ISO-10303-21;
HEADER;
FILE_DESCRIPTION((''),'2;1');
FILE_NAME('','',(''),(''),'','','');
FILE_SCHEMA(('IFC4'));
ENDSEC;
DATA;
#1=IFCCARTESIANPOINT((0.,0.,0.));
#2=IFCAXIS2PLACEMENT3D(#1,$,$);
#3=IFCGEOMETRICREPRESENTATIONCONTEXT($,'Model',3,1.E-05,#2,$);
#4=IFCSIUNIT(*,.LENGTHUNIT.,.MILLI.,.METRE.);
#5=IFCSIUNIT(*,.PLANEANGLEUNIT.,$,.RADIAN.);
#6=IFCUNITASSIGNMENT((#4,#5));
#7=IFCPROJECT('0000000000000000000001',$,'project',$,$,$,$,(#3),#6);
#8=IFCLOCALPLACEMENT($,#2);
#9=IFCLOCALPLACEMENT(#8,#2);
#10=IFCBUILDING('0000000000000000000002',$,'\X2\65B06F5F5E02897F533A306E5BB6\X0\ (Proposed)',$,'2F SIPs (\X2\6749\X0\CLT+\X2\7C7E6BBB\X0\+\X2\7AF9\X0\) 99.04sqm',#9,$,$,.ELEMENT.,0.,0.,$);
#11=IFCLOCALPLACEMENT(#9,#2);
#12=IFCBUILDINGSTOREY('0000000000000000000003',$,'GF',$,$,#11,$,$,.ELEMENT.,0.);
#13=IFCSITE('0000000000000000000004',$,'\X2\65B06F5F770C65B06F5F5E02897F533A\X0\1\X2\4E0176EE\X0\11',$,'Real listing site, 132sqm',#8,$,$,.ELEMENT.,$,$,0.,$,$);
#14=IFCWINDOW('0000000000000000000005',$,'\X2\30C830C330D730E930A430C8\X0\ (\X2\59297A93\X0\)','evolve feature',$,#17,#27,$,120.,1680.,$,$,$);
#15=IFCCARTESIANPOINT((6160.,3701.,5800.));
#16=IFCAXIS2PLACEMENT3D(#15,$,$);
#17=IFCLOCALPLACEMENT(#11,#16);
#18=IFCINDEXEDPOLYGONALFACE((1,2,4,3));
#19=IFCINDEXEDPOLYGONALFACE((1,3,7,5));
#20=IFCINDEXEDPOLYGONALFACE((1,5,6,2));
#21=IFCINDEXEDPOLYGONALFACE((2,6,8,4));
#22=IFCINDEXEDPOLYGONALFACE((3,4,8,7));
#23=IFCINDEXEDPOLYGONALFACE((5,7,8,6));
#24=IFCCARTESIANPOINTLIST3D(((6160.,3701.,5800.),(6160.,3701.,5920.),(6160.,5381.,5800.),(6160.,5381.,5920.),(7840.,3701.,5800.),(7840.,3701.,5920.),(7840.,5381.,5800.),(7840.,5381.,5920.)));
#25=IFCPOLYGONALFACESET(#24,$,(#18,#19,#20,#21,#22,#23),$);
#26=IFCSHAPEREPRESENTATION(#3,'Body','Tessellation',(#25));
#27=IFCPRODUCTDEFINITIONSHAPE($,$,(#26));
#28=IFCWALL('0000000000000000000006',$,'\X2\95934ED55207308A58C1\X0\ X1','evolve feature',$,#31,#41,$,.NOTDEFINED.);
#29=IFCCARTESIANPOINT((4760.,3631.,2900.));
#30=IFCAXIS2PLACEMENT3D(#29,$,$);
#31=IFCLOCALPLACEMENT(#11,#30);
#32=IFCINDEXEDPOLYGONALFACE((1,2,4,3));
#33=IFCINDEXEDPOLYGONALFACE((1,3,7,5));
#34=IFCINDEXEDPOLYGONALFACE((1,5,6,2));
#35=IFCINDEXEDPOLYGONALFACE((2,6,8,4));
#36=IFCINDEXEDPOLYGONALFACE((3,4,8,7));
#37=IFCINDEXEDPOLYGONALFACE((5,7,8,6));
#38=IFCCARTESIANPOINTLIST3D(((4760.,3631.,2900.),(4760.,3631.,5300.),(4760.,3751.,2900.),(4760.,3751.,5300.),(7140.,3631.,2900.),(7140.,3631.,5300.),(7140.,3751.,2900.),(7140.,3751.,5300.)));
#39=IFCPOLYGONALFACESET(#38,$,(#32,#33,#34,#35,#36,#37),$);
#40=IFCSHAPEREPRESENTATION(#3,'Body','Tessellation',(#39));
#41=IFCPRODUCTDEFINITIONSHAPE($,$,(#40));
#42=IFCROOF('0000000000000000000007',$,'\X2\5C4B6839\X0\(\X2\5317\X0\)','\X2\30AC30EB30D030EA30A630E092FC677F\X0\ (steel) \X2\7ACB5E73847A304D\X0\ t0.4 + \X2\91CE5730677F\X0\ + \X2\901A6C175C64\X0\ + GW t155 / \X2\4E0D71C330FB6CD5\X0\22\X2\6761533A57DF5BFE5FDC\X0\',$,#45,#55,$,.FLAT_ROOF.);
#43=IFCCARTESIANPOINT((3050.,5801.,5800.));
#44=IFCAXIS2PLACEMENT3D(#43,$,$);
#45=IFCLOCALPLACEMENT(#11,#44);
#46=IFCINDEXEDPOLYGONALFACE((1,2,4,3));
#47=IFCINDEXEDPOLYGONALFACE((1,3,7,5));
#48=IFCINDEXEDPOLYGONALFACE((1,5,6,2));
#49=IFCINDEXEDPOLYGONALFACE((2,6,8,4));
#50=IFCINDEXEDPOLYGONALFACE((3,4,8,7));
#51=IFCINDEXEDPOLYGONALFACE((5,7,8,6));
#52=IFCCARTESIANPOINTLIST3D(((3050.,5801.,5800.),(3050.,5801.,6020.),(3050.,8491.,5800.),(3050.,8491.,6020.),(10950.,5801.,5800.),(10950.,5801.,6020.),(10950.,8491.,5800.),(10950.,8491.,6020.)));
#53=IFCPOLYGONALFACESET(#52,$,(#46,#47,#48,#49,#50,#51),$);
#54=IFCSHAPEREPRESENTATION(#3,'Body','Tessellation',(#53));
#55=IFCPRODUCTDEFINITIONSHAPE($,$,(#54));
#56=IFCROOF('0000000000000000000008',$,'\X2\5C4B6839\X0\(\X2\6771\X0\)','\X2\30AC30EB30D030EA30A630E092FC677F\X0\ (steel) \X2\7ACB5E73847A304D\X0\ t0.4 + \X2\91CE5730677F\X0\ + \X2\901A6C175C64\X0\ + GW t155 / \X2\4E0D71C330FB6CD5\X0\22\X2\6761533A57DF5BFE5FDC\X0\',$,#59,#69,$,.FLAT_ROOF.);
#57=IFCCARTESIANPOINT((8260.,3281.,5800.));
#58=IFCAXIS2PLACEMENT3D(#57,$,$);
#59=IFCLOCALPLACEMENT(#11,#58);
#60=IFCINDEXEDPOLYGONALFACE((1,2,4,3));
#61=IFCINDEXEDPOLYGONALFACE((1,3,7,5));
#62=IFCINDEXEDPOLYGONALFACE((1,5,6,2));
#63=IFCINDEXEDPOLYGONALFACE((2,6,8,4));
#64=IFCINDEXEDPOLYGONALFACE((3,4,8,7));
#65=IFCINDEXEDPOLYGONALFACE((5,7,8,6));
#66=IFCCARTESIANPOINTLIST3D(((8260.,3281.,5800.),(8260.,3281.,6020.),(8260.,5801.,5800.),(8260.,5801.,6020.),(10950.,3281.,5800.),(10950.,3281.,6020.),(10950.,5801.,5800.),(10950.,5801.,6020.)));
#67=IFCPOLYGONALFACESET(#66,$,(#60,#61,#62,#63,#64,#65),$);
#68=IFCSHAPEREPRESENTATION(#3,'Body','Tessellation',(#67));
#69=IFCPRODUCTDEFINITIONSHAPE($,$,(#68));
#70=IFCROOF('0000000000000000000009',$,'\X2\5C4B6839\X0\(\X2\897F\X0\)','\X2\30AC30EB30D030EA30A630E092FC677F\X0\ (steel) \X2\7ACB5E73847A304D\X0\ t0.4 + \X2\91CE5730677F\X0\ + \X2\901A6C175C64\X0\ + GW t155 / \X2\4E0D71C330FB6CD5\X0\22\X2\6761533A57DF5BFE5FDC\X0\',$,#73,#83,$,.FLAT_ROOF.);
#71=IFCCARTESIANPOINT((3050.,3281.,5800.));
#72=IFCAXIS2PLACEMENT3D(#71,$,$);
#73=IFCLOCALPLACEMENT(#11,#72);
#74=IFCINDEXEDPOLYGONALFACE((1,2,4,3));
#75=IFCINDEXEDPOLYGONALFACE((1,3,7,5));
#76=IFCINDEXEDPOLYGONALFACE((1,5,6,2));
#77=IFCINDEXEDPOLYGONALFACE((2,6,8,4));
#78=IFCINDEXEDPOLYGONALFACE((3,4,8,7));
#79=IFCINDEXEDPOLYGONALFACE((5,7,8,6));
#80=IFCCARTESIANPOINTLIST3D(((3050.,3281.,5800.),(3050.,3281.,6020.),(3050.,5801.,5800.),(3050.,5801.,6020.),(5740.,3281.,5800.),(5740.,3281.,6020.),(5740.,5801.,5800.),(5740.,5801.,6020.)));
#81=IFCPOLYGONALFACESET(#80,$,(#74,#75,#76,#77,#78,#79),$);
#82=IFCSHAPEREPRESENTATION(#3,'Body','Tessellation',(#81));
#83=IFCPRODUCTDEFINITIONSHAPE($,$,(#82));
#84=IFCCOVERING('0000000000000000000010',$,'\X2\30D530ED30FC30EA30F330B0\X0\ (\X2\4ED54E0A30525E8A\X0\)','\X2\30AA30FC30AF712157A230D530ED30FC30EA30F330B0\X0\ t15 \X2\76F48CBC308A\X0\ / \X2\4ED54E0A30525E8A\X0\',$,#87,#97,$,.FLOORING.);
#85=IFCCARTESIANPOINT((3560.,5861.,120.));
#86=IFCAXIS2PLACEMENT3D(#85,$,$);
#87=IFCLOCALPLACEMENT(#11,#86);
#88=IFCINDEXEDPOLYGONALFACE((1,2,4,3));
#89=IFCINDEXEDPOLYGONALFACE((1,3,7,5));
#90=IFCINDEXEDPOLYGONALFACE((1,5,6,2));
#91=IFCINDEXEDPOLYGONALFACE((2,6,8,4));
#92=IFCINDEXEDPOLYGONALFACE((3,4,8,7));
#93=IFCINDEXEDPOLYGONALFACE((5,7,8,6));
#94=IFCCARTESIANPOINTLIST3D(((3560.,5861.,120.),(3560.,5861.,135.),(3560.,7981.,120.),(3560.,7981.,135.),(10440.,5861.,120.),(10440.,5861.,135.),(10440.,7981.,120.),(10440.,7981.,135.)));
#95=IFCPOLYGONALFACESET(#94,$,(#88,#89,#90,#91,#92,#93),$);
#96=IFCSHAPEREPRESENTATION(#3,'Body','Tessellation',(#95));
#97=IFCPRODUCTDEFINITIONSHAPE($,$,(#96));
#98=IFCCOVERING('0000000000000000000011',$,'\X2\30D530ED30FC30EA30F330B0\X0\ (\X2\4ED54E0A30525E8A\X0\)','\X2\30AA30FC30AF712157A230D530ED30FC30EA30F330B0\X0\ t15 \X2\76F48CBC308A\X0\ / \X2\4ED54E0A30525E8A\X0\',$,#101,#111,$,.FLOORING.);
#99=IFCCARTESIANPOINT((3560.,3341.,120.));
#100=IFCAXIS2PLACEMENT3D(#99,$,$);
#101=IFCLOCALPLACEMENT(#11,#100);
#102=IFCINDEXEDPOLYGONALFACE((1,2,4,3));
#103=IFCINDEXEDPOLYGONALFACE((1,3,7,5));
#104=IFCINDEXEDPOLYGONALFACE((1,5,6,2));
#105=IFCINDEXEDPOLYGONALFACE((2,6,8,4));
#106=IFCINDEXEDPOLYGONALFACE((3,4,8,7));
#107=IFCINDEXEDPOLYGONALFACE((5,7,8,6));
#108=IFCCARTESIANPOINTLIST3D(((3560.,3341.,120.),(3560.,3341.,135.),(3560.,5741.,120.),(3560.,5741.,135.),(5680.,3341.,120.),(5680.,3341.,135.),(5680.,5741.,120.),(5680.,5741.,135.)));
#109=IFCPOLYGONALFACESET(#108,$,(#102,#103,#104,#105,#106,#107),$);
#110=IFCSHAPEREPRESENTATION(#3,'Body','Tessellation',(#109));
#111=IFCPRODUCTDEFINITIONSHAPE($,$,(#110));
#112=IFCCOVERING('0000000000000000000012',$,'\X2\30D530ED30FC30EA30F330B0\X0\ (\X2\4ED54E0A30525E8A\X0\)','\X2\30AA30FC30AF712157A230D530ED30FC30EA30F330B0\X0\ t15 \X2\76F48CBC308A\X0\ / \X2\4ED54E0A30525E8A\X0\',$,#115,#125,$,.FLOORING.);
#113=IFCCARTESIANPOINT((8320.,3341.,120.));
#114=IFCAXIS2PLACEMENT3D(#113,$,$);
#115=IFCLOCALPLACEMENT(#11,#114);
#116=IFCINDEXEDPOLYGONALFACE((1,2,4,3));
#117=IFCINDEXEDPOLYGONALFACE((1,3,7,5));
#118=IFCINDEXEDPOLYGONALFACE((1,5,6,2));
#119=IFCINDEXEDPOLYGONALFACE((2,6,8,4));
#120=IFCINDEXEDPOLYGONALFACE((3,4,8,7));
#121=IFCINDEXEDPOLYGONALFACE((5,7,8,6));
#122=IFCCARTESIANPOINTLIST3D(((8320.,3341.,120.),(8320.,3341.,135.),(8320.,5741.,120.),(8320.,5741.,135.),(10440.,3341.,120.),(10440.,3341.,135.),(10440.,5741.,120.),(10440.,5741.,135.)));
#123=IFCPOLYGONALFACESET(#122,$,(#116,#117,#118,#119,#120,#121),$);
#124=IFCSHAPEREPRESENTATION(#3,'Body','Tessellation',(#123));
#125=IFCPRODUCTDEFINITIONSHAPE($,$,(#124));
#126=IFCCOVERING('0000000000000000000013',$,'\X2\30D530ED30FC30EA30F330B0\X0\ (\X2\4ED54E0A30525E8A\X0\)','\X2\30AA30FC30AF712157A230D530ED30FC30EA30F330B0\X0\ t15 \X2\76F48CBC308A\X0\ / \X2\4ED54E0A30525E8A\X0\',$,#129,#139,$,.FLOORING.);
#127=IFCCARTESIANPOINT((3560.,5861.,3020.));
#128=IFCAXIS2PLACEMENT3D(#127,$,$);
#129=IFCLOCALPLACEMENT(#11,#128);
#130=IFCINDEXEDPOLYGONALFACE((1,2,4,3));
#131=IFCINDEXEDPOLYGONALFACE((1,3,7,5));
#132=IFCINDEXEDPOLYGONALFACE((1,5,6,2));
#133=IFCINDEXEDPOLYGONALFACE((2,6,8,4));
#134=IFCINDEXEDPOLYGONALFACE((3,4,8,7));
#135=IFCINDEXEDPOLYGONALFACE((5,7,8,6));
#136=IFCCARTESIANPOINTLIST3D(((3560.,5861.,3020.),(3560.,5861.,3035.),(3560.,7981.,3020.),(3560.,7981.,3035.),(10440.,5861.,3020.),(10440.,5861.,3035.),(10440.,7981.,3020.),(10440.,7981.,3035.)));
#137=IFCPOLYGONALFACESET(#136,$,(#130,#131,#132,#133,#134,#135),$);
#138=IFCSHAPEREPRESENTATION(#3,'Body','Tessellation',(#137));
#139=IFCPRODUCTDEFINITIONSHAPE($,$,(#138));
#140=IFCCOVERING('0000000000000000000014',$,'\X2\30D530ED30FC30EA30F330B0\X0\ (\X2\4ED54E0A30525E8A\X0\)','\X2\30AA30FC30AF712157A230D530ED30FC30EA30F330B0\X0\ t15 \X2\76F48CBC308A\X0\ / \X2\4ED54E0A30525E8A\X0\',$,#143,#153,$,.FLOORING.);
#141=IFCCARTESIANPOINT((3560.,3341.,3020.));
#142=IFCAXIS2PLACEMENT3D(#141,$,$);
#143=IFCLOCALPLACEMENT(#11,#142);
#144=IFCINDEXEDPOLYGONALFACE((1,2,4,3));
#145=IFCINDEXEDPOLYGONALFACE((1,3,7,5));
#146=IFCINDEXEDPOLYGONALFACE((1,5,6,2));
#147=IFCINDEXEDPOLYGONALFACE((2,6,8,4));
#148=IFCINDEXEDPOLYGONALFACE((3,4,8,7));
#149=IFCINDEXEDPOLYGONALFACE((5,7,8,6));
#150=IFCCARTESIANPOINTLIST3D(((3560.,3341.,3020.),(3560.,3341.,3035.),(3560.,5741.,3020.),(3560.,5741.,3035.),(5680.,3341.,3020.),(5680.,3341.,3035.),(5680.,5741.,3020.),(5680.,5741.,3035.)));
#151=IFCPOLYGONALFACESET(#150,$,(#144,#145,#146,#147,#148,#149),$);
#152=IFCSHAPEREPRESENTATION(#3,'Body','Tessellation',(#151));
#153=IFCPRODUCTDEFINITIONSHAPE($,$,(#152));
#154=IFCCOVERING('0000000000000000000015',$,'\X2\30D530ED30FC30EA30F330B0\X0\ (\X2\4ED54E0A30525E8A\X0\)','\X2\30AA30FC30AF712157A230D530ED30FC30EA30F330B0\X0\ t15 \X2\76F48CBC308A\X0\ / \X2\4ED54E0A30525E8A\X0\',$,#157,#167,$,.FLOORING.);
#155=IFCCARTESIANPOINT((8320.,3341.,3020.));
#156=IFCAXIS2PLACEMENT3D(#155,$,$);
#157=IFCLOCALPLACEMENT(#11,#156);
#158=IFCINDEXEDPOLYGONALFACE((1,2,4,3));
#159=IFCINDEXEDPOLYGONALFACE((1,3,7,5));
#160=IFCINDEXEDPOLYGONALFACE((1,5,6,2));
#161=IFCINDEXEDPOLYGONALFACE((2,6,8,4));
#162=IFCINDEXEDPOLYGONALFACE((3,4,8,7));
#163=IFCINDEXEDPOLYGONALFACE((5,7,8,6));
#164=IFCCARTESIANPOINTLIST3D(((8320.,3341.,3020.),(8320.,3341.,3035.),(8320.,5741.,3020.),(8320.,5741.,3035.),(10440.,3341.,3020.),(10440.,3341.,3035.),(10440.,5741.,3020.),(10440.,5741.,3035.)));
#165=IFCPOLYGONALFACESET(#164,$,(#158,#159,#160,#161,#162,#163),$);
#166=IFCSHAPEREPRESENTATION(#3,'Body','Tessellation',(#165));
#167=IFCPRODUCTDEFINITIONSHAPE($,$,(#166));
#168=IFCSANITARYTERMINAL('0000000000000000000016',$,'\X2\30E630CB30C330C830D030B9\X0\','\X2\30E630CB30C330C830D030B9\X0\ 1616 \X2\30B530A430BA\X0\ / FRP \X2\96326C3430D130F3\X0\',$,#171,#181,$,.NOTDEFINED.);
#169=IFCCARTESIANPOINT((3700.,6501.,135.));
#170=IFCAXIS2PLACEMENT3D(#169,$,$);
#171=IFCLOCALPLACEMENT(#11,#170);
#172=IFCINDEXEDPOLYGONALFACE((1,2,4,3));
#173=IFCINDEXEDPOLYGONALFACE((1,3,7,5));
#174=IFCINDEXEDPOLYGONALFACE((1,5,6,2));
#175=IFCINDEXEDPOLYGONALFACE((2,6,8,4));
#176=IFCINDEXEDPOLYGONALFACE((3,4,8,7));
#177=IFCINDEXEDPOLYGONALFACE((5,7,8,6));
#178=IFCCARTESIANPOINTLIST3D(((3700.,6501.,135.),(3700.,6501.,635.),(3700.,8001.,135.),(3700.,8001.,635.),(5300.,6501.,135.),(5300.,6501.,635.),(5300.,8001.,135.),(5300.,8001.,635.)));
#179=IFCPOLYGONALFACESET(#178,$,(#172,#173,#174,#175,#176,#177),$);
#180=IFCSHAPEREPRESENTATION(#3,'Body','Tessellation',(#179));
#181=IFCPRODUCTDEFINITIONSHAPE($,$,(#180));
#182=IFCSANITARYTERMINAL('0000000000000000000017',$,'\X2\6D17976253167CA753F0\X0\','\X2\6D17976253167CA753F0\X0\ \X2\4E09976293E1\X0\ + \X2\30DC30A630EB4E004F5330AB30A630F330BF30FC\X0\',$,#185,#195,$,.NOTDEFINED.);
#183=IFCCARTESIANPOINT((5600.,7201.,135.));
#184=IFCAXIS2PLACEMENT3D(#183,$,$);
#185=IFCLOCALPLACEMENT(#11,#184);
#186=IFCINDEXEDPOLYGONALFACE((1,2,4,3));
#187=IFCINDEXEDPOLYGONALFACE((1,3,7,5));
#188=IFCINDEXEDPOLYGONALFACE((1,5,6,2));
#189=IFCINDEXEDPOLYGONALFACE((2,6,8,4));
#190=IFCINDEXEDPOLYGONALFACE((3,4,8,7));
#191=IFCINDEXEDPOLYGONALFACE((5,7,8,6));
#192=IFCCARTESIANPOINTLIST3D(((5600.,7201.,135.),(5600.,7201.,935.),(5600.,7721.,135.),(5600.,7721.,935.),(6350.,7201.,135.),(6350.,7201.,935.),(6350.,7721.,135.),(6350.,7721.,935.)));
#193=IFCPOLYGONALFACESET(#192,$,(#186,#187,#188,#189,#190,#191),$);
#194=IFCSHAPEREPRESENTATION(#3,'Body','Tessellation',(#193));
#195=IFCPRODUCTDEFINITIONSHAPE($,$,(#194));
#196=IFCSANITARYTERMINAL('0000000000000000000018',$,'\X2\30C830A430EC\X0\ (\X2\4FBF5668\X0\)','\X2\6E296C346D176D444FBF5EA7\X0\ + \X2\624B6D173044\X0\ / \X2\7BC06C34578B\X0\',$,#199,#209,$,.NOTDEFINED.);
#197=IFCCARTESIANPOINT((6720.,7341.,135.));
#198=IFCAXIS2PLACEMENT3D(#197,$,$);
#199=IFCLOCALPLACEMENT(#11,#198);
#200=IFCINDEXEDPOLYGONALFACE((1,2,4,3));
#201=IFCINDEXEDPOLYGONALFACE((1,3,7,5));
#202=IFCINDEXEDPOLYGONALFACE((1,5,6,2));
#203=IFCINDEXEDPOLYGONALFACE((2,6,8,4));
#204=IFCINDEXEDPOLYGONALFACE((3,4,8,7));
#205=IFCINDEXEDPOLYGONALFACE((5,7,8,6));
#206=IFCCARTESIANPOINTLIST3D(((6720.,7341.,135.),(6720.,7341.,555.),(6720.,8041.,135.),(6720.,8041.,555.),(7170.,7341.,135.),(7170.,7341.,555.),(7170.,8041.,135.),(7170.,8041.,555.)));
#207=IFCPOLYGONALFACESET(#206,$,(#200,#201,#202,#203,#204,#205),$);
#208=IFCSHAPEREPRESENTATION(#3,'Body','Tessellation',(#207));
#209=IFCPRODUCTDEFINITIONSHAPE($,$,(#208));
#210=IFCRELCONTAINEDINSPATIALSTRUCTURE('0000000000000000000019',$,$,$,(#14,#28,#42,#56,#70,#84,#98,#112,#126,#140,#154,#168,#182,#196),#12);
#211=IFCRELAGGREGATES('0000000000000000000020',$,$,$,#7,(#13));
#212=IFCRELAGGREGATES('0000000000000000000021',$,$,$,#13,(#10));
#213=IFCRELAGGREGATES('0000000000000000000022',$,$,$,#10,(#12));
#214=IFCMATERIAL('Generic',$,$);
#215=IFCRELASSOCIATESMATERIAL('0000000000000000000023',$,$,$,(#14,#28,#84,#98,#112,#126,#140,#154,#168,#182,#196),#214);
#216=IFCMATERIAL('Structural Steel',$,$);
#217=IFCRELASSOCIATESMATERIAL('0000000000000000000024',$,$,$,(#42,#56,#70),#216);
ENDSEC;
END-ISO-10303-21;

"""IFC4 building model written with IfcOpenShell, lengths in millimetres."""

from ifc_helpers import new_model, si_unit, frame, frame_2d, origin, place, context, project, spatial, rectangle, extrude, material, element, save


model = new_model("IFC4")

# Units and contexts
model_context = context("Model", 3, precision=1e-05, world=origin())
ifc_project = project(units=[si_unit("LENGTHUNIT", "METRE", prefix="MILLI"), si_unit("PLANEANGLEUNIT", "RADIAN")], contexts=[model_context])

# Site, building, storey
site_placement = place(None, origin())
site = spatial("IfcSite", under=ifc_project, at=site_placement, Name="新潟県新潟市西区1丁目11", ObjectType="Real listing site, 132sqm", CompositionType="ELEMENT", RefElevation=0.0)
building_placement = place(site_placement, origin())
building = spatial("IfcBuilding", under=site, at=building_placement, Name="新潟市西区の家 (Proposed)", ObjectType="2F SIPs (杉CLT+籾殻+竹) 99.04sqm", CompositionType="ELEMENT", ElevationOfRefHeight=0.0, ElevationOfTerrain=0.0)
storey_placement = place(building_placement, origin())
storey = spatial("IfcBuildingStorey", under=building, at=storey_placement, Name="GF", CompositionType="ELEMENT", Elevation=0.0)

# Window
ifc_material_1 = material(Name="Generic")
window_1_placement = place(storey_placement, frame((6160.0, 3701.0, 5800.0)))
element("IfcWindow", 1, at=window_1_placement, inside=storey, material=ifc_material_1, Name="トップライト (天窓)", Description="evolve feature", OverallHeight=120.0, OverallWidth=1680.0, context=model_context, shape_type="SweptSolid", body=[
    extrude(rectangle(XDim=1680.0, YDim=1680.0, at=frame_2d((840.0, 840.0))), frame((6160.0, 3701.0, 5800.0)), (0.0, 0.0, 1.0), 120.0),
])

# Wall
wall_1_placement = place(storey_placement, frame((4760.0, 3631.0, 2900.0)))
element("IfcWall", 2, at=wall_1_placement, inside=storey, material=ifc_material_1, Name="間仕切り壁 X1", Description="evolve feature", PredefinedType="NOTDEFINED", context=model_context, shape_type="SweptSolid", body=[
    extrude(rectangle(XDim=2380.0, YDim=120.0, at=frame_2d((1190.0, 60.0))), frame((4760.0, 3631.0, 2900.0)), (0.0, 0.0, 1.0), 2400.0),
])

# Roofs
ifc_material_2 = material(Name="Structural Steel")
roof_1_placement = place(storey_placement, frame((3050.0, 5801.0, 5800.0)))
element("IfcRoof", 3, at=roof_1_placement, inside=storey, material=ifc_material_2, Name="屋根(北)", Description="ガルバリウム鋼板 (steel) 立平葺き t0.4 + 野地板 + 通気層 + GW t155 / 不燃・法22条区域対応", PredefinedType="FLAT_ROOF", context=model_context, shape_type="SweptSolid", body=[
    extrude(rectangle(XDim=7900.0, YDim=2690.0, at=frame_2d((3950.0, 1345.0))), frame((3050.0, 5801.0, 5800.0)), (0.0, 0.0, 1.0), 220.0),
])
roof_2_placement = place(storey_placement, frame((8260.0, 3281.0, 5800.0)))
element("IfcRoof", 4, at=roof_2_placement, inside=storey, material=ifc_material_2, Name="屋根(東)", Description="ガルバリウム鋼板 (steel) 立平葺き t0.4 + 野地板 + 通気層 + GW t155 / 不燃・法22条区域対応", PredefinedType="FLAT_ROOF", context=model_context, shape_type="SweptSolid", body=[
    extrude(rectangle(XDim=2690.0, YDim=2520.0, at=frame_2d((1345.0, 1260.0))), frame((8260.0, 3281.0, 5800.0)), (0.0, 0.0, 1.0), 220.0),
])
roof_3_placement = place(storey_placement, frame((3050.0, 3281.0, 5800.0)))
element("IfcRoof", 5, at=roof_3_placement, inside=storey, material=ifc_material_2, Name="屋根(西)", Description="ガルバリウム鋼板 (steel) 立平葺き t0.4 + 野地板 + 通気層 + GW t155 / 不燃・法22条区域対応", PredefinedType="FLAT_ROOF", context=model_context, shape_type="SweptSolid", body=[
    extrude(rectangle(XDim=2690.0, YDim=2520.0, at=frame_2d((1345.0, 1260.0))), frame((3050.0, 3281.0, 5800.0)), (0.0, 0.0, 1.0), 220.0),
])

# Coverings
covering_1_placement = place(storey_placement, frame((3560.0, 5861.0, 120.0)))
element("IfcCovering", 6, at=covering_1_placement, inside=storey, material=ifc_material_1, Name="フローリング (仕上げ床)", Description="オーク無垢フローリング t15 直貼り / 仕上げ床", PredefinedType="FLOORING", context=model_context, shape_type="SweptSolid", body=[
    extrude(rectangle(XDim=6880.0, YDim=2120.0, at=frame_2d((3440.0, 1060.0))), frame((3560.0, 5861.0, 120.0)), (0.0, 0.0, 1.0), 15.0),
])
covering_2_placement = place(storey_placement, frame((3560.0, 3341.0, 120.0)))
element("IfcCovering", 7, at=covering_2_placement, inside=storey, material=ifc_material_1, Name="フローリング (仕上げ床)", Description="オーク無垢フローリング t15 直貼り / 仕上げ床", PredefinedType="FLOORING", context=model_context, shape_type="SweptSolid", body=[
    extrude(rectangle(XDim=2120.0, YDim=2400.0, at=frame_2d((1060.0, 1200.0))), frame((3560.0, 3341.0, 120.0)), (0.0, 0.0, 1.0), 15.0),
])
covering_3_placement = place(storey_placement, frame((8320.0, 3341.0, 120.0)))
element("IfcCovering", 8, at=covering_3_placement, inside=storey, material=ifc_material_1, Name="フローリング (仕上げ床)", Description="オーク無垢フローリング t15 直貼り / 仕上げ床", PredefinedType="FLOORING", context=model_context, shape_type="SweptSolid", body=[
    extrude(rectangle(XDim=2120.0, YDim=2400.0, at=frame_2d((1060.0, 1200.0))), frame((8320.0, 3341.0, 120.0)), (0.0, 0.0, 1.0), 15.0),
])
covering_4_placement = place(storey_placement, frame((3560.0, 5861.0, 3020.0)))
element("IfcCovering", 9, at=covering_4_placement, inside=storey, material=ifc_material_1, Name="フローリング (仕上げ床)", Description="オーク無垢フローリング t15 直貼り / 仕上げ床", PredefinedType="FLOORING", context=model_context, shape_type="SweptSolid", body=[
    extrude(rectangle(XDim=6880.0, YDim=2120.0, at=frame_2d((3440.0, 1060.0))), frame((3560.0, 5861.0, 3020.0)), (0.0, 0.0, 1.0), 15.0),
])
covering_5_placement = place(storey_placement, frame((3560.0, 3341.0, 3020.0)))
element("IfcCovering", 10, at=covering_5_placement, inside=storey, material=ifc_material_1, Name="フローリング (仕上げ床)", Description="オーク無垢フローリング t15 直貼り / 仕上げ床", PredefinedType="FLOORING", context=model_context, shape_type="SweptSolid", body=[
    extrude(rectangle(XDim=2120.0, YDim=2400.0, at=frame_2d((1060.0, 1200.0))), frame((3560.0, 3341.0, 3020.0)), (0.0, 0.0, 1.0), 15.0),
])
covering_6_placement = place(storey_placement, frame((8320.0, 3341.0, 3020.0)))
element("IfcCovering", 11, at=covering_6_placement, inside=storey, material=ifc_material_1, Name="フローリング (仕上げ床)", Description="オーク無垢フローリング t15 直貼り / 仕上げ床", PredefinedType="FLOORING", context=model_context, shape_type="SweptSolid", body=[
    extrude(rectangle(XDim=2120.0, YDim=2400.0, at=frame_2d((1060.0, 1200.0))), frame((8320.0, 3341.0, 3020.0)), (0.0, 0.0, 1.0), 15.0),
])

# Sanitary terminals
sanitary_terminal_1_placement = place(storey_placement, frame((3700.0, 6501.0, 135.0)))
element("IfcSanitaryTerminal", 12, at=sanitary_terminal_1_placement, inside=storey, material=ifc_material_1, Name="ユニットバス", Description="ユニットバス 1616 サイズ / FRP 防水パン", PredefinedType="NOTDEFINED", context=model_context, shape_type="SweptSolid", body=[
    extrude(rectangle(XDim=1600.0, YDim=1500.0, at=frame_2d((800.0, 750.0))), frame((3700.0, 6501.0, 135.0)), (0.0, 0.0, 1.0), 500.0),
])
sanitary_terminal_2_placement = place(storey_placement, frame((5600.0, 7201.0, 135.0)))
element("IfcSanitaryTerminal", 13, at=sanitary_terminal_2_placement, inside=storey, material=ifc_material_1, Name="洗面化粧台", Description="洗面化粧台 三面鏡 + ボウル一体カウンター", PredefinedType="NOTDEFINED", context=model_context, shape_type="SweptSolid", body=[
    extrude(rectangle(XDim=750.0, YDim=520.0, at=frame_2d((375.0, 260.0))), frame((5600.0, 7201.0, 135.0)), (0.0, 0.0, 1.0), 800.0),
])
sanitary_terminal_3_placement = place(storey_placement, frame((6720.0, 7341.0, 135.0)))
element("IfcSanitaryTerminal", 14, at=sanitary_terminal_3_placement, inside=storey, material=ifc_material_1, Name="トイレ (便器)", Description="温水洗浄便座 + 手洗い / 節水型", PredefinedType="NOTDEFINED", context=model_context, shape_type="SweptSolid", body=[
    extrude(rectangle(XDim=450.0, YDim=700.0, at=frame_2d((225.0, 350.0))), frame((6720.0, 7341.0, 135.0)), (0.0, 0.0, 1.0), 420.0),
])

save(model, "model.ifc")
